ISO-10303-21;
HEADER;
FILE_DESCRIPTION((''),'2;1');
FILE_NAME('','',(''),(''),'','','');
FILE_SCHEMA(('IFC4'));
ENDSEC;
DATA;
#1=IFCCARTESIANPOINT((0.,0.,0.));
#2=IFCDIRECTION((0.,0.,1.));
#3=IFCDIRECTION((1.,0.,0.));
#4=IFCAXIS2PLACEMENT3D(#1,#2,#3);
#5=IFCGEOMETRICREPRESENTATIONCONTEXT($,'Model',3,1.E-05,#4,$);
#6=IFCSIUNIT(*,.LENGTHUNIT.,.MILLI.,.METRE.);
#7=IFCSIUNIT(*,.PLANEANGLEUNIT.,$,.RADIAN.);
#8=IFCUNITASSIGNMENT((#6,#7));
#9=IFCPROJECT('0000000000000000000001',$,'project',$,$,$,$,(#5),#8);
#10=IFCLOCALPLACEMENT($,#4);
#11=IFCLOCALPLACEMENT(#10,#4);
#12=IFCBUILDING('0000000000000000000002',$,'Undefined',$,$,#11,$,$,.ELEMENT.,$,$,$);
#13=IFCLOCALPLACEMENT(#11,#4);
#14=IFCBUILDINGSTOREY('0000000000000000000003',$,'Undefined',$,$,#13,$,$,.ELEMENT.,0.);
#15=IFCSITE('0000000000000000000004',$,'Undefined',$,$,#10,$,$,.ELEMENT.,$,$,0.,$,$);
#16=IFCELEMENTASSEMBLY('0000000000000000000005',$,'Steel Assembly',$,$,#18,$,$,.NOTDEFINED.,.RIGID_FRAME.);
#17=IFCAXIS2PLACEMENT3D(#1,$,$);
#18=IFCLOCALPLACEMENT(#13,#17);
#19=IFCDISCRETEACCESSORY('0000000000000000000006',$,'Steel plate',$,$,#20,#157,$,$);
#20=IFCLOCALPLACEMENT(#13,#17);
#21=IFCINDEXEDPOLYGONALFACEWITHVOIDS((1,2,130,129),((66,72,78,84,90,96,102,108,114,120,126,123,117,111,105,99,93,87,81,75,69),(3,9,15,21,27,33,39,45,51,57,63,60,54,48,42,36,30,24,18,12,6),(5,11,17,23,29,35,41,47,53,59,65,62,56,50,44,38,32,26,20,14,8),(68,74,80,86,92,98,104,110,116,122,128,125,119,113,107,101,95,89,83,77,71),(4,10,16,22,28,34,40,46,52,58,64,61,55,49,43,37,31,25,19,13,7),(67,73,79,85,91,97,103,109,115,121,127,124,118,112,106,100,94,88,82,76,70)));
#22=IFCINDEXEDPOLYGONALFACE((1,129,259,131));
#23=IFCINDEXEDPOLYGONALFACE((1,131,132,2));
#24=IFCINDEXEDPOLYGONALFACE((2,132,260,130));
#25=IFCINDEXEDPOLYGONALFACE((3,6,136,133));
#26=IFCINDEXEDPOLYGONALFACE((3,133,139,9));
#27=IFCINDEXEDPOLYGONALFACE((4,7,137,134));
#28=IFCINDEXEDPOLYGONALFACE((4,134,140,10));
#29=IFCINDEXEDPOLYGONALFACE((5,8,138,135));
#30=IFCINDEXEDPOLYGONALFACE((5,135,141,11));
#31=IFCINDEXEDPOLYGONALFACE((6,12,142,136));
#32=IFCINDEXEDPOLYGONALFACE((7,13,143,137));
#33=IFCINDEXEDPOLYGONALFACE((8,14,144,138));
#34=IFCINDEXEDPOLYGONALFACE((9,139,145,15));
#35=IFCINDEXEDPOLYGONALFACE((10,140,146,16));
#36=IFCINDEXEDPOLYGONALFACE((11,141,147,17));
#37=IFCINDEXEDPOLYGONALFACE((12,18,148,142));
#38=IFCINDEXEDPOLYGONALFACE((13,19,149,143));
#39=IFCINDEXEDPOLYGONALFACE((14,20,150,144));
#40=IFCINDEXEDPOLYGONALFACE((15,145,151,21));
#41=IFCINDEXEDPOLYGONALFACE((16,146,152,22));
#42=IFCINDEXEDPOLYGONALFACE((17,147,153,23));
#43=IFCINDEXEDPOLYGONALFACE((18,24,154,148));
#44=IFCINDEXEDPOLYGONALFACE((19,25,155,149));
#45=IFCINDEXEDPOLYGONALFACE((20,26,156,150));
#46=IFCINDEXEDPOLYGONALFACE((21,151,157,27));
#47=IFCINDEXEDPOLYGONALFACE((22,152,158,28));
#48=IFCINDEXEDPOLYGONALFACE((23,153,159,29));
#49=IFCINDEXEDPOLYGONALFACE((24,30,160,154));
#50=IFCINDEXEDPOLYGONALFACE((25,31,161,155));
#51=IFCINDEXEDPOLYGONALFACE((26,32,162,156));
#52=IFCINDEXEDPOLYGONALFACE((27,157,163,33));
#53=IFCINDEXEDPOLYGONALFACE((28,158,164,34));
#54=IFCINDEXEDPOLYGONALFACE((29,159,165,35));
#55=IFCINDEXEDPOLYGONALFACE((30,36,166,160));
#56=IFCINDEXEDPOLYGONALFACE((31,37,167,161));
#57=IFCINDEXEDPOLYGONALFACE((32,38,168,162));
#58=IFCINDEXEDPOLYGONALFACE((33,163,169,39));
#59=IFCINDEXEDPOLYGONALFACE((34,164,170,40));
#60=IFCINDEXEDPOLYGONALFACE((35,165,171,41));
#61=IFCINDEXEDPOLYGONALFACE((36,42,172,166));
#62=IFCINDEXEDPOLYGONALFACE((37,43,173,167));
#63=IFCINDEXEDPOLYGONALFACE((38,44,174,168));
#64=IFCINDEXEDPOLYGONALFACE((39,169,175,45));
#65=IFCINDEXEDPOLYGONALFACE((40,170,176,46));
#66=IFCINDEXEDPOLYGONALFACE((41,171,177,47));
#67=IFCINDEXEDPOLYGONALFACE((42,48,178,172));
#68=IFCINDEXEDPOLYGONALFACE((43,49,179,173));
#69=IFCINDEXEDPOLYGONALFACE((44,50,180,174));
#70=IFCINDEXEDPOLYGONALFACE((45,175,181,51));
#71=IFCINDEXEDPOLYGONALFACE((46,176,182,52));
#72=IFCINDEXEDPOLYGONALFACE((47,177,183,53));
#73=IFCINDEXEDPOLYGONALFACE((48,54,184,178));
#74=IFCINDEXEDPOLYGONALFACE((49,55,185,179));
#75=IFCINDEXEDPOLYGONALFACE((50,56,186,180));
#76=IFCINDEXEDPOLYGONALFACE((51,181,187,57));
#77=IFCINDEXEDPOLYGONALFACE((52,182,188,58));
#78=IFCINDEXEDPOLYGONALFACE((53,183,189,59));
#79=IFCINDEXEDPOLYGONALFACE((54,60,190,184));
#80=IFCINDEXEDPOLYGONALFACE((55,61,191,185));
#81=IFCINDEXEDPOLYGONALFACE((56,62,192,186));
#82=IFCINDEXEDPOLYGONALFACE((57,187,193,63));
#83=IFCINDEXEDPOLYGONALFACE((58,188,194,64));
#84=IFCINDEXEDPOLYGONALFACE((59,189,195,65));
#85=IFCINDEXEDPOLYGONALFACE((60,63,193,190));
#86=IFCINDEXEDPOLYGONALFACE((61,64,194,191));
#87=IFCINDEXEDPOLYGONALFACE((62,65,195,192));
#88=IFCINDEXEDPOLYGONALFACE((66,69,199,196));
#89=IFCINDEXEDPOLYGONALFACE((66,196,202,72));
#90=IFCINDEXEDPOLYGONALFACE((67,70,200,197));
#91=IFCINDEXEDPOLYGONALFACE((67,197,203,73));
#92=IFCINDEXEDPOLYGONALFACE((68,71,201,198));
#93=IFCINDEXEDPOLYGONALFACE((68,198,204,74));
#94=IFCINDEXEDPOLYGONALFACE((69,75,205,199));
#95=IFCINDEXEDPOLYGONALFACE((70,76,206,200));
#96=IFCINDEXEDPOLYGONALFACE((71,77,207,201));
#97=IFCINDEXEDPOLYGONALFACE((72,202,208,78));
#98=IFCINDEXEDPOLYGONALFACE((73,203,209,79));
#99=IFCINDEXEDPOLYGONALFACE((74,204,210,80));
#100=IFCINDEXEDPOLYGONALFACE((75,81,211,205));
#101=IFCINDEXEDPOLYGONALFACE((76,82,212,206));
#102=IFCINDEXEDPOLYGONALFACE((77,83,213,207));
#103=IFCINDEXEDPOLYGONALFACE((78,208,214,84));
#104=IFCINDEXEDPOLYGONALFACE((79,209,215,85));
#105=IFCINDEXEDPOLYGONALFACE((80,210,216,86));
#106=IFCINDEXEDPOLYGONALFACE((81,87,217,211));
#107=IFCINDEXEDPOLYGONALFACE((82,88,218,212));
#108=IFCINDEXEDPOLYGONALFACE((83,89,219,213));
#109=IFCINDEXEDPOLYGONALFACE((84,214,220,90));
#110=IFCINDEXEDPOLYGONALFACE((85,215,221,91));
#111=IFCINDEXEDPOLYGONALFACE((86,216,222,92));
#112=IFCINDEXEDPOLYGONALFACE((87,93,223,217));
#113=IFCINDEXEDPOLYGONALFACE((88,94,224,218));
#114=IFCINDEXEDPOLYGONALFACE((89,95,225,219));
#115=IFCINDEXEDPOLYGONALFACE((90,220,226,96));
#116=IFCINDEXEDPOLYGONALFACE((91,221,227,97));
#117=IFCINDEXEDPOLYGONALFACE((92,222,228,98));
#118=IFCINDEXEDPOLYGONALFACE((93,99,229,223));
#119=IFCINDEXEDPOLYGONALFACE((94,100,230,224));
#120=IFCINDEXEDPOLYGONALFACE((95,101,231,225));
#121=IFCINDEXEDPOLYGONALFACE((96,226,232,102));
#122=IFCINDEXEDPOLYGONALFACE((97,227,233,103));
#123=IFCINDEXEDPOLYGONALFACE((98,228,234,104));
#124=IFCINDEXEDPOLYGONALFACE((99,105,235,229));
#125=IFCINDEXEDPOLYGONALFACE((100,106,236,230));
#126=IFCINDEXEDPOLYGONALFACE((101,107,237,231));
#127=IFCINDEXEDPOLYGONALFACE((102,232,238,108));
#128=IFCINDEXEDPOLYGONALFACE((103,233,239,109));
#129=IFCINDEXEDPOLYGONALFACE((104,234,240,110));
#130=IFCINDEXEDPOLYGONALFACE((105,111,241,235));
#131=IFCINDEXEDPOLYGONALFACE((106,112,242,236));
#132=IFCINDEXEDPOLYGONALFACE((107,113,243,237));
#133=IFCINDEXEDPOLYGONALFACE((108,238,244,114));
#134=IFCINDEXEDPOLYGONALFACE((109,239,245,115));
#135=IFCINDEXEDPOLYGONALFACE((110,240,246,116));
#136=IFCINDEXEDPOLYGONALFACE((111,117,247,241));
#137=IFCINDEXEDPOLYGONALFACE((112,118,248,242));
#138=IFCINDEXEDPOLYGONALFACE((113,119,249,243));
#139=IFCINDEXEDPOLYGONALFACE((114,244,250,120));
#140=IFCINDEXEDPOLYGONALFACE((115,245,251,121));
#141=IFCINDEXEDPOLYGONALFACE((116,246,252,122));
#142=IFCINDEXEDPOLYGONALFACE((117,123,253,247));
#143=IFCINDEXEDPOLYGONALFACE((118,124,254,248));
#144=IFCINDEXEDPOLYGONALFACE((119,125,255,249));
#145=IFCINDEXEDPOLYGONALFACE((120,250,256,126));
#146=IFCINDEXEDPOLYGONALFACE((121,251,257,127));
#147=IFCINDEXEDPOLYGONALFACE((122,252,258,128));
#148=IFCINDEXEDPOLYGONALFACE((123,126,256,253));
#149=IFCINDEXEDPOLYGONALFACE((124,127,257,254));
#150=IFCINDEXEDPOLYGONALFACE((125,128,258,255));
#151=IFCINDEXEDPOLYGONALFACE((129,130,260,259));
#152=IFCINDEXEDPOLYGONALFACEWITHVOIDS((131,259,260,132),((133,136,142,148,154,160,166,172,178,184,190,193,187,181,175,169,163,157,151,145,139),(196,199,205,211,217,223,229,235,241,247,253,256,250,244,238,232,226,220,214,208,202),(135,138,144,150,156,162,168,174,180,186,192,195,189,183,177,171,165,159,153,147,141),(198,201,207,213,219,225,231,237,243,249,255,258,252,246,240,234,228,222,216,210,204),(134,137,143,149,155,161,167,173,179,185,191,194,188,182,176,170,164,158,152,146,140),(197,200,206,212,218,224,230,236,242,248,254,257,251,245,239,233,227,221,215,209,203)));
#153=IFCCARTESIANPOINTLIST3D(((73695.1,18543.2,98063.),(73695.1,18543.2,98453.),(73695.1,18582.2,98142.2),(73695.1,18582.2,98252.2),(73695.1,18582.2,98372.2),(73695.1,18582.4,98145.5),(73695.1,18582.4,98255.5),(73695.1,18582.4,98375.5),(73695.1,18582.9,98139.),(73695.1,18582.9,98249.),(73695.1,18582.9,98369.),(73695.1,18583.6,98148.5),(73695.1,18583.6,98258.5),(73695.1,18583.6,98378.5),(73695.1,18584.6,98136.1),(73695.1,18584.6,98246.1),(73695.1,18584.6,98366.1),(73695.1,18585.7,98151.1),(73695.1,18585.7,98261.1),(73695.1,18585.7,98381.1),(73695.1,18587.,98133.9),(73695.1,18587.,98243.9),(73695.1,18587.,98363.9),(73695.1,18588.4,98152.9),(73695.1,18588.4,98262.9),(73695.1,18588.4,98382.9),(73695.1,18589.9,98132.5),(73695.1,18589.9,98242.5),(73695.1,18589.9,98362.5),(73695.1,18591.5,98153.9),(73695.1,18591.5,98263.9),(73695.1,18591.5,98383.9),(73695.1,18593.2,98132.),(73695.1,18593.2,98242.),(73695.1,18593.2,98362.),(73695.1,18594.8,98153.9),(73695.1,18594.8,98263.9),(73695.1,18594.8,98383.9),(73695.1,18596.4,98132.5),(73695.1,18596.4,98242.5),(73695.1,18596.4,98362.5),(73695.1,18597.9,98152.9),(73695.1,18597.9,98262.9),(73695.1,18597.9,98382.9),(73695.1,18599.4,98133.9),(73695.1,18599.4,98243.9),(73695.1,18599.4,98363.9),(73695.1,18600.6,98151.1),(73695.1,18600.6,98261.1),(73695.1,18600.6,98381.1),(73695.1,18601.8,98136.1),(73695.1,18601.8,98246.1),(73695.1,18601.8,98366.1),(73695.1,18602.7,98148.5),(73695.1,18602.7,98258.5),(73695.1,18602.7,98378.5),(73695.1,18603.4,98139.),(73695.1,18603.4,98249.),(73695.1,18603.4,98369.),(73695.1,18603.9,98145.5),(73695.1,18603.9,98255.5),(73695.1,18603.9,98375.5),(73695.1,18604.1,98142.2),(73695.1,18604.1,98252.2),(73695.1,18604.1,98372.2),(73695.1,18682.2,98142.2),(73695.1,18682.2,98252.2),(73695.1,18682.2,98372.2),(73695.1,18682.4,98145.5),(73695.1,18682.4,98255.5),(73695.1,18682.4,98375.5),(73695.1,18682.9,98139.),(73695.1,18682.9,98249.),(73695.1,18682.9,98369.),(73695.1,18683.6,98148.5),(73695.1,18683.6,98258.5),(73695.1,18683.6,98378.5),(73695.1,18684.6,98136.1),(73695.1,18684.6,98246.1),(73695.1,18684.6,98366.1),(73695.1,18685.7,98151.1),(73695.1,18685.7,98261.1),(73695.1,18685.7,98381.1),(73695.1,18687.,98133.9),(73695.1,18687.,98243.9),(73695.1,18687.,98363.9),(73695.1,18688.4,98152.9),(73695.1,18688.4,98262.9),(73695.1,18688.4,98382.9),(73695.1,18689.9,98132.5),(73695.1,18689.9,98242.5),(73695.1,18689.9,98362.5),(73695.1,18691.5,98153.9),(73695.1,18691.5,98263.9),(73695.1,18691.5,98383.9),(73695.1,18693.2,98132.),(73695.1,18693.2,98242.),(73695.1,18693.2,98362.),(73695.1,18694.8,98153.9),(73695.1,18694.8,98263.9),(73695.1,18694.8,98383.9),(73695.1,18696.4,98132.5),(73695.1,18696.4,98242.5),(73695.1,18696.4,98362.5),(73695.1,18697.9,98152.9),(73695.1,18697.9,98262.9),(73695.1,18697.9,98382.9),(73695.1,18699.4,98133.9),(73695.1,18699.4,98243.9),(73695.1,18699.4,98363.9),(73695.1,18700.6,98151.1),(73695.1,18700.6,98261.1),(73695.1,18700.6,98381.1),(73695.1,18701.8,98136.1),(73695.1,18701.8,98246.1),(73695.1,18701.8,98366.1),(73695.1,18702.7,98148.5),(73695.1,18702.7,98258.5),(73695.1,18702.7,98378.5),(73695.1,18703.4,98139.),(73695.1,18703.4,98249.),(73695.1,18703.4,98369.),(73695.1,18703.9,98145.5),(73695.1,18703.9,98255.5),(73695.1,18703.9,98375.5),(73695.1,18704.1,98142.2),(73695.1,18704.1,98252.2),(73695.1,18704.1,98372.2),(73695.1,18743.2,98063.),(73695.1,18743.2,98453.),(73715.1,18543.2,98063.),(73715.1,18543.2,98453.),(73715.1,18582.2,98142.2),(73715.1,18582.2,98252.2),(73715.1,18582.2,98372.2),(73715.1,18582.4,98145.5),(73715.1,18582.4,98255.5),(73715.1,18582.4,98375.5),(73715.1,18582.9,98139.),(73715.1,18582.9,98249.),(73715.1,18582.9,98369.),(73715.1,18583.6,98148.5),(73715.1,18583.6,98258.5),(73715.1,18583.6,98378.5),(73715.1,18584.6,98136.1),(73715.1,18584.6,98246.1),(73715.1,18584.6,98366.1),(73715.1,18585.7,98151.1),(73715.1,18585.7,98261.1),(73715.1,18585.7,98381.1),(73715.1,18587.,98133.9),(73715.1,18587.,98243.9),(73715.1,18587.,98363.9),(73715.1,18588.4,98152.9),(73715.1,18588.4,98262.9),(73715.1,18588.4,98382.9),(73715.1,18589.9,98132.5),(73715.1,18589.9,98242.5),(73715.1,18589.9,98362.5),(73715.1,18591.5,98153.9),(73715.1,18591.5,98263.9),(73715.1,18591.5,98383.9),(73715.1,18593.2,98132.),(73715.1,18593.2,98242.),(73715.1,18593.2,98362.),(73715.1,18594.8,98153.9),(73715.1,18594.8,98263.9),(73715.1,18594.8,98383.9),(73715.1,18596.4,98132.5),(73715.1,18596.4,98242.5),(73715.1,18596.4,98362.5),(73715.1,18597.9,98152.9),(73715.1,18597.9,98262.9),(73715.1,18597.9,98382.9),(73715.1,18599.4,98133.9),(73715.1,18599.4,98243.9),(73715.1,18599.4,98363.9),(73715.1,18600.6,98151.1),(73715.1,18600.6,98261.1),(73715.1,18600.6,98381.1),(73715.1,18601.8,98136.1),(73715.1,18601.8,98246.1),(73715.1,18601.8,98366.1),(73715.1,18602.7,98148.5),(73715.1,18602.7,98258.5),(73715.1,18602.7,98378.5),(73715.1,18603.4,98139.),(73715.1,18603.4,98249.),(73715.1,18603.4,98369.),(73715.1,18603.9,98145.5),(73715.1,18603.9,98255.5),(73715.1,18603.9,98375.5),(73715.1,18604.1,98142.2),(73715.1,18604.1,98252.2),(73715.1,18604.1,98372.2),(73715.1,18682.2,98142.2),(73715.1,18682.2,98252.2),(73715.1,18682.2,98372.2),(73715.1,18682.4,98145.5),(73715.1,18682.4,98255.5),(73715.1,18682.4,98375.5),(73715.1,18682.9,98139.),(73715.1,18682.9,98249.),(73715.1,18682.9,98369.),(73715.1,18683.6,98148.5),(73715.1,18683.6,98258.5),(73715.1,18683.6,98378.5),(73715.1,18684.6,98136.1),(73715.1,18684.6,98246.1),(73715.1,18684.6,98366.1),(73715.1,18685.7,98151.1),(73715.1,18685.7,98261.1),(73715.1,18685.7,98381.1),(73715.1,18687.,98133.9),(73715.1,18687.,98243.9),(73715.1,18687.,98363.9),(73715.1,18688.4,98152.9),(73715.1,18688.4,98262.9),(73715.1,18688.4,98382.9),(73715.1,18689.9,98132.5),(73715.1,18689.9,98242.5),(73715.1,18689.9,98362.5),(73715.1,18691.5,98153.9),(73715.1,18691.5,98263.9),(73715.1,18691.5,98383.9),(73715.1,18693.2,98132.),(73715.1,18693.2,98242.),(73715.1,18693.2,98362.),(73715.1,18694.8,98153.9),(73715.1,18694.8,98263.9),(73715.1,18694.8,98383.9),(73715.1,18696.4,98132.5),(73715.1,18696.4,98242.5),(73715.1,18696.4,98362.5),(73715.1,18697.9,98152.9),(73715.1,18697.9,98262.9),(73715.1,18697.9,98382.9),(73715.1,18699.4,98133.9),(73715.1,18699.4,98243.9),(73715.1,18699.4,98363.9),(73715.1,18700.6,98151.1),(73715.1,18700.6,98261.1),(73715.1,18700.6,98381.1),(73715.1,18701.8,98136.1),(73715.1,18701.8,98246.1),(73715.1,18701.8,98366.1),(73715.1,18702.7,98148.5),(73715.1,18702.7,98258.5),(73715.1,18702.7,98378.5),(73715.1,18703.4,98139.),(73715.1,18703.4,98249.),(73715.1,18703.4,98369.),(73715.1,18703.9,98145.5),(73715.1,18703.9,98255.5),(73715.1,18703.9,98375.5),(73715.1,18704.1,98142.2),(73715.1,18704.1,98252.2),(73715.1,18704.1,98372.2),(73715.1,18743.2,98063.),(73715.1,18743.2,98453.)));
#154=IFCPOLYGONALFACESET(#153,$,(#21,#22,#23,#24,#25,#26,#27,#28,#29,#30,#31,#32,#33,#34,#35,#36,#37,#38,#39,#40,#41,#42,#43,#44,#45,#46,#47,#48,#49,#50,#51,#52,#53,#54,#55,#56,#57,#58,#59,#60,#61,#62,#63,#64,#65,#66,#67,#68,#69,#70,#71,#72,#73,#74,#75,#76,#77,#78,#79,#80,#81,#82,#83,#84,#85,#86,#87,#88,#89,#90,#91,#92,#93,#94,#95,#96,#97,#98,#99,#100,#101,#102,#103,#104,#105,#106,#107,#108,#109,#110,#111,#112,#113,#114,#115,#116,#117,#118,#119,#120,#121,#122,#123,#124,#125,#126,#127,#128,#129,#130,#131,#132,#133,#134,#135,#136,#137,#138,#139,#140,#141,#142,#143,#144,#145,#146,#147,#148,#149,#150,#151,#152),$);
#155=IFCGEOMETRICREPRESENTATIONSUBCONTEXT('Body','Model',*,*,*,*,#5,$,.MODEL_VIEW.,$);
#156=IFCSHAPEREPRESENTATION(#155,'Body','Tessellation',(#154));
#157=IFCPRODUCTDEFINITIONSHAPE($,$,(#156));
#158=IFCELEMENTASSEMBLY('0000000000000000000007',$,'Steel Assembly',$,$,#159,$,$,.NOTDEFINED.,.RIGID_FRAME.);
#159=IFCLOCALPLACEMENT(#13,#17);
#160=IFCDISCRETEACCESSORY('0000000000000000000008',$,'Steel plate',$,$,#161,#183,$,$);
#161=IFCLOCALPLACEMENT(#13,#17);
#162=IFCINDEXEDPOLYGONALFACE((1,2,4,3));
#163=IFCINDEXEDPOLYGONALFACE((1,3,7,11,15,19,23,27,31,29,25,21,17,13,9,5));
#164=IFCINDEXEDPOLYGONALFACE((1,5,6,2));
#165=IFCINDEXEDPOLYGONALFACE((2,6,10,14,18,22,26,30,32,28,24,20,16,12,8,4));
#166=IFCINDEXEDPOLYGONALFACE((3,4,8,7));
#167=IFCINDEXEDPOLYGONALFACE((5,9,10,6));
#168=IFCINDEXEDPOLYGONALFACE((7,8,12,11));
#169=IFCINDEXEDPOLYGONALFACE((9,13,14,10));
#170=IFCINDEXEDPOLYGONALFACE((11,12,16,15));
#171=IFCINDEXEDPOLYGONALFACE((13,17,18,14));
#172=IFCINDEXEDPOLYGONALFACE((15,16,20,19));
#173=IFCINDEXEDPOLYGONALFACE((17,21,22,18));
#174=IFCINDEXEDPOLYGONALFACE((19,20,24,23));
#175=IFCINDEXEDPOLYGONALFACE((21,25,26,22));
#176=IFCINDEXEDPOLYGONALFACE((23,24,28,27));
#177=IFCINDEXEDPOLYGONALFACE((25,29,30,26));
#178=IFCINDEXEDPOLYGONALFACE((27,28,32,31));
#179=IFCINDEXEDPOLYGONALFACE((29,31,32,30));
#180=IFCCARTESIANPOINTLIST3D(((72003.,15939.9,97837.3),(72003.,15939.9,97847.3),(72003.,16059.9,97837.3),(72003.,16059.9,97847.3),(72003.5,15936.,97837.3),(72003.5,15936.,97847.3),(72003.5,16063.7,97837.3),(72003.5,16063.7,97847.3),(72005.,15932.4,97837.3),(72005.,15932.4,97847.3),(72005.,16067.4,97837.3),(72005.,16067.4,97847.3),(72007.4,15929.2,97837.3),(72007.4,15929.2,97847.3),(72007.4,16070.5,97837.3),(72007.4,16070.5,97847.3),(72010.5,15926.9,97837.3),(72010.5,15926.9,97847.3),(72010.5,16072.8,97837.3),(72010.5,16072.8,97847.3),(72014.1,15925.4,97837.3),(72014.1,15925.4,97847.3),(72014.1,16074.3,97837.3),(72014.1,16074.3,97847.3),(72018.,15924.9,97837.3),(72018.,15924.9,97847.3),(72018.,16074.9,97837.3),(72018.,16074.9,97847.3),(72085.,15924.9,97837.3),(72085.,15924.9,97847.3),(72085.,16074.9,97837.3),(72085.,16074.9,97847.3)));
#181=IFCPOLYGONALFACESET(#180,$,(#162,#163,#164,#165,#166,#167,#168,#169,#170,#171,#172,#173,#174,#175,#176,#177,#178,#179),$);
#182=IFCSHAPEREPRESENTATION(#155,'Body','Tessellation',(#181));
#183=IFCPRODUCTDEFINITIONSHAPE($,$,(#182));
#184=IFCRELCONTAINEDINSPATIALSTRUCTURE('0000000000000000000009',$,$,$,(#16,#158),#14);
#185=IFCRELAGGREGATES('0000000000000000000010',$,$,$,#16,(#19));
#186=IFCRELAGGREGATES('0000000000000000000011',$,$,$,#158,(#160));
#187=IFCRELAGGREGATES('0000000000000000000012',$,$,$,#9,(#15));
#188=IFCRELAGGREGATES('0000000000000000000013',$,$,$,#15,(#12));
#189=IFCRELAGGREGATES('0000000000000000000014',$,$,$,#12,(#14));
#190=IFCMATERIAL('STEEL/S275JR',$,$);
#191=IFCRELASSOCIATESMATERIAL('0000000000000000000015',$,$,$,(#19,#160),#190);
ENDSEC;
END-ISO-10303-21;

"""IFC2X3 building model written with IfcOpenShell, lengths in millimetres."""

from ifc_helpers import new_model, si_unit, frame, frame_2d, origin_with_axes, origin_2d_with_axis, place, context, subcontext, project, spatial, polyline, circle_curve, parameter, trimmed, segment, composite_curve, circle, outline, extrude, source, transform, mapped, material, element, aggregate, save


model = new_model("IFC2X3")

# Units and contexts
model_context = context("Model", 3, precision=1e-05, world=origin_with_axes())
body_context = subcontext(model_context, "Body", "Model", "MODEL_VIEW")
ifc_project = project(units=[si_unit("LENGTHUNIT", "METRE", prefix="MILLI"), si_unit("PLANEANGLEUNIT", "RADIAN")], contexts=[model_context])

# Site, building, storey
site_placement = place(None, origin_with_axes())
site = spatial("IfcSite", under=ifc_project, at=site_placement, Name="Undefined", CompositionType="ELEMENT", RefElevation=0.0)
building_placement = place(site_placement, origin_with_axes())
building = spatial("IfcBuilding", under=site, at=building_placement, Name="Undefined", CompositionType="ELEMENT")
storey_placement = place(building_placement, origin_with_axes())
storey = spatial("IfcBuildingStorey", under=building, at=storey_placement, Name="Undefined", CompositionType="ELEMENT", Elevation=0.0)

# Shared definitions
ifc_material_1 = material(Name="STEEL/S275JR")

# Shared definitions
shared_shape_1 = source(origin_with_axes(), body_context, "Body", "SweptSolid", [
    extrude(circle(Radius=11.0, at=origin_2d_with_axis()), frame((0.0, -20.1, 0.0), z_axis=(0.0, 1.0, 0.0), x_axis=(1.0, 0.0, 0.0)), (0.0, 0.0, 1.0), 40.3),
])

# Element assembly, discrete accessory, opening
assembly_1_placement = place(storey_placement, origin_with_axes())
assembly_1 = element("IfcElementAssembly", 1, at=assembly_1_placement, inside=storey, Name="Steel Assembly", AssemblyPlace="NOTDEFINED", PredefinedType="RIGID_FRAME")
discrete_accessory_1_placement = place(assembly_1_placement, frame((73705.1, 18543.2, 98453.0), z_axis=(-1.0, 0.0, 0.0), x_axis=(0.0, 1.0, 0.0)))
discrete_accessory_1 = element("IfcDiscreteAccessory", 2, at=discrete_accessory_1_placement, material=ifc_material_1, Name="Steel plate", context=body_context, shape_type="SweptSolid", body=[
    extrude(outline(polyline([(0.0, 0.0), (200.0, 0.0), (200.0, 390.0), (0.0, 390.0), (0.0, 0.0)])), frame((0.0, 0.0, -10.0), z_axis=(0.0, 0.0, 1.0), x_axis=(1.0, 0.0, 0.0)), (0.0, 0.0, 1.0), 20.0),
])
opening_1_placement = place(assembly_1_placement, frame((73695.1, 18643.2, 98373.0), z_axis=(0.0, 1.0, 0.0), x_axis=(0.0, 0.0, -1.0)))
element("IfcOpeningElement", 3, at=opening_1_placement, cuts=discrete_accessory_1, ObjectType="Opening", context=body_context, shape_type="MappedRepresentation", body=[
    mapped(shared_shape_1, transform((0.0, 0.0, -50.0))),
    mapped(shared_shape_1, transform((120.0, 0.0, -50.0))),
    mapped(shared_shape_1, transform((230.0, 0.0, -50.0))),
    mapped(shared_shape_1, transform((0.0, 0.0, 50.0))),
    mapped(shared_shape_1, transform((120.0, 0.0, 50.0))),
    mapped(shared_shape_1, transform((230.0, 0.0, 50.0))),
])
aggregate(assembly_1, [discrete_accessory_1])

# Element assembly, discrete accessory
assembly_2_placement = place(storey_placement, origin_with_axes())
assembly_2 = element("IfcElementAssembly", 4, at=assembly_2_placement, inside=storey, Name="Steel Assembly", AssemblyPlace="NOTDEFINED", PredefinedType="RIGID_FRAME")
discrete_accessory_2_placement = place(assembly_2_placement, frame((72003.0, 16074.9, 97842.3), z_axis=(0.0, 0.0, -1.0), x_axis=(1.0, 0.0, 0.0)))
discrete_accessory_2 = element("IfcDiscreteAccessory", 5, at=discrete_accessory_2_placement, material=ifc_material_1, Name="Steel plate", context=body_context, shape_type="SweptSolid", body=[
    extrude(outline(composite_curve([segment(trimmed(circle_curve(frame_2d((15.0, 15.0), x_axis=(-1.0, 0.0)), 15.0), [parameter(0.0)], [parameter(1.570796)], True, "PARAMETER"), True, "CONTINUOUS"), segment(polyline([(15.0, 0.0), (82.0, 0.0), (82.0, 150.0), (15.0, 150.0)]), True, "CONTINUOUS"), segment(trimmed(circle_curve(frame_2d((15.0, 135.0), x_axis=(0.0, 1.0)), 15.0), [parameter(0.0)], [parameter(1.570796)], True, "PARAMETER"), True, "CONTINUOUS"), segment(polyline([(0.0, 135.0), (0.0, 15.0)]), True, "DISCONTINUOUS")], self_intersect=False)), frame((0.0, 0.0, -5.0), z_axis=(0.0, 0.0, 1.0), x_axis=(1.0, 0.0, 0.0)), (0.0, 0.0, 1.0), 10.0),
])
aggregate(assembly_2, [discrete_accessory_2])

save(model, "model.ifc")
